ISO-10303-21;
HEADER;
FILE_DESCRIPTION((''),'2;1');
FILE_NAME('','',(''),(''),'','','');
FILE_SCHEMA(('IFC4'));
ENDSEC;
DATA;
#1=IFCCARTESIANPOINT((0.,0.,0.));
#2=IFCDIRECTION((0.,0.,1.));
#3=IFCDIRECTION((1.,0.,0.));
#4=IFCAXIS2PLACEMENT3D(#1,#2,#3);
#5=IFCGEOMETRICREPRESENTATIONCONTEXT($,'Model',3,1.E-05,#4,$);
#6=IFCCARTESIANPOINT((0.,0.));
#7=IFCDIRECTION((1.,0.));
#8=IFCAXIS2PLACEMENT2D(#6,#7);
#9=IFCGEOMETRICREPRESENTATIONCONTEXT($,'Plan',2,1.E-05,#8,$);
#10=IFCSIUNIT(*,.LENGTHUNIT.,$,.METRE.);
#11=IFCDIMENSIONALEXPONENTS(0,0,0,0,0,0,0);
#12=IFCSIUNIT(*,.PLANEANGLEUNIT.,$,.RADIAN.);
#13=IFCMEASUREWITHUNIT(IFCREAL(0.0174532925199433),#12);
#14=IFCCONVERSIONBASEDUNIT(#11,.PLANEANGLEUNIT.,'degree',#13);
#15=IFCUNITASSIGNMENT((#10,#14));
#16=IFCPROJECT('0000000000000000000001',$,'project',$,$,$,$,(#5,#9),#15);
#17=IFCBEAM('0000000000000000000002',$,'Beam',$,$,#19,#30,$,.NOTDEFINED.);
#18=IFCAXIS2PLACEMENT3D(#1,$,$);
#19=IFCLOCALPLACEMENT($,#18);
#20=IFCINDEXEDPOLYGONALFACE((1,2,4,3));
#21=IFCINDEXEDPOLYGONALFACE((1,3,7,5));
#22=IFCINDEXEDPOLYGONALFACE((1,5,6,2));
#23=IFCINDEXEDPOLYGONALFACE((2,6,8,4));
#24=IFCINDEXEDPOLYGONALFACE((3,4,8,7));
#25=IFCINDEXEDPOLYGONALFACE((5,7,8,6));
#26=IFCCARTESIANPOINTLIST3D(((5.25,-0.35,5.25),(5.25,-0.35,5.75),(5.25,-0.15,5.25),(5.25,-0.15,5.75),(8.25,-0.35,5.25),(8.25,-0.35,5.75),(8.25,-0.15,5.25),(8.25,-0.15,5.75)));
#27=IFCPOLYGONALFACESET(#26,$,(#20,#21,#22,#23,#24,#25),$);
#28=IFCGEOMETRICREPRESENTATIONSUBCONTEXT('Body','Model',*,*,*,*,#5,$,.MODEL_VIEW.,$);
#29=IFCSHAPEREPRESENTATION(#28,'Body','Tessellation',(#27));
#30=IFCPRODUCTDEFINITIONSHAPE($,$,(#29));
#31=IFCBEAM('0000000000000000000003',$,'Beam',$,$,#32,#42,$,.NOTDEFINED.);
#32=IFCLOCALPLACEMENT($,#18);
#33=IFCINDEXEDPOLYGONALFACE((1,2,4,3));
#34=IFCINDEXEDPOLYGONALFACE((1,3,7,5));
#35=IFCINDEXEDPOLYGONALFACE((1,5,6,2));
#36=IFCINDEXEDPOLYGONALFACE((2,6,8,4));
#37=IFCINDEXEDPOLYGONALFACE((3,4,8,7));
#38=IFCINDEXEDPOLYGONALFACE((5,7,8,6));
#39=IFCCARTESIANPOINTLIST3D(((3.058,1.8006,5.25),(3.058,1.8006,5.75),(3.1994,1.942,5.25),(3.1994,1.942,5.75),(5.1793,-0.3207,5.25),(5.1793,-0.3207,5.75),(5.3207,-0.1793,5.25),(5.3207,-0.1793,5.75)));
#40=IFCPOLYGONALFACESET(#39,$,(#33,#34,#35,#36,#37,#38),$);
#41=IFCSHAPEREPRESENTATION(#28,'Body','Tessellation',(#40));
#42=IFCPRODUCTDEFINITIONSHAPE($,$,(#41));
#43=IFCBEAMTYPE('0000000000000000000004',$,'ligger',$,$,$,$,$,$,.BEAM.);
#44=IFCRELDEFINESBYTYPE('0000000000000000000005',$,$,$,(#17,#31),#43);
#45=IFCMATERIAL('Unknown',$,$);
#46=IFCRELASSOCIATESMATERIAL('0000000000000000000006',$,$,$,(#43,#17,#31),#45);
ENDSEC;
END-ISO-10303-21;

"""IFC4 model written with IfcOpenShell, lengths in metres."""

from ifc_helpers import new_model, entity, si_unit, converted_unit, frame, origin_with_axes, origin_2d_with_axis, place, context, subcontext, project, rectangle, extrude, material, material_profile, profile_set, profile_usage, type_object, element, save


model = new_model("IFC4")

# Units and contexts
model_context = context("Model", 3, precision=1e-05, world=origin_with_axes())
plan_context = context("Plan", 2, precision=1e-05, world=origin_2d_with_axis())
body_context = subcontext(model_context, "Body", "Model", "MODEL_VIEW")
ifc_project = project(units=[si_unit("LENGTHUNIT", "METRE"), converted_unit("PLANEANGLEUNIT", "degree", entity("IfcReal", 0.0174532925199433), si_unit("PLANEANGLEUNIT", "RADIAN"), dimensions=[0, 0, 0, 0, 0, 0, 0])], contexts=[model_context, plan_context])

# Beams
ifc_material = material(Name="Unknown")
ifc_material_profile_1 = material_profile(ifc_material, rectangle(XDim=0.2, YDim=0.5))
ifc_material_profile_2 = material_profile(ifc_material, rectangle(XDim=0.2, YDim=0.4))
ifc_profile_set = profile_set([ifc_material_profile_1, ifc_material_profile_2])
ifc_profile_usage_1 = profile_usage(ifc_profile_set, cardinal=5)
beam_type = type_object("IfcBeamType", Name="ligger", PredefinedType="BEAM", material=ifc_profile_set)
beam_1_placement = place(None, frame((5.25, -0.25, 5.5), z_axis=(1.0, 0.0, 0.0), x_axis=(0.0, 1.0, 0.0)))
element("IfcBeam", 1, at=beam_1_placement, type_object=beam_type, material=ifc_profile_usage_1, Name="Beam", PredefinedType="NOTDEFINED", context=body_context, shape_type="SweptSolid", body=[
    extrude(rectangle(XDim=0.2, YDim=0.5), origin_with_axes(), (0.0, 0.0, 1.0), 3.0),
])
ifc_profile_usage_2 = profile_usage(ifc_profile_set, cardinal=5)
beam_2_placement = place(None, frame((5.25, -0.25, 5.5), z_axis=(-0.707107, 0.707107, 0.0), x_axis=(-0.707107, -0.707107, 0.0)))
element("IfcBeam", 2, at=beam_2_placement, type_object=beam_type, material=ifc_profile_usage_2, Name="Beam", PredefinedType="NOTDEFINED", context=body_context, shape_type="SweptSolid", body=[
    extrude(rectangle(XDim=0.2, YDim=0.5), origin_with_axes(), (0.0, 0.0, 1.0), 3.0),
])

save(model, "model.ifc")
